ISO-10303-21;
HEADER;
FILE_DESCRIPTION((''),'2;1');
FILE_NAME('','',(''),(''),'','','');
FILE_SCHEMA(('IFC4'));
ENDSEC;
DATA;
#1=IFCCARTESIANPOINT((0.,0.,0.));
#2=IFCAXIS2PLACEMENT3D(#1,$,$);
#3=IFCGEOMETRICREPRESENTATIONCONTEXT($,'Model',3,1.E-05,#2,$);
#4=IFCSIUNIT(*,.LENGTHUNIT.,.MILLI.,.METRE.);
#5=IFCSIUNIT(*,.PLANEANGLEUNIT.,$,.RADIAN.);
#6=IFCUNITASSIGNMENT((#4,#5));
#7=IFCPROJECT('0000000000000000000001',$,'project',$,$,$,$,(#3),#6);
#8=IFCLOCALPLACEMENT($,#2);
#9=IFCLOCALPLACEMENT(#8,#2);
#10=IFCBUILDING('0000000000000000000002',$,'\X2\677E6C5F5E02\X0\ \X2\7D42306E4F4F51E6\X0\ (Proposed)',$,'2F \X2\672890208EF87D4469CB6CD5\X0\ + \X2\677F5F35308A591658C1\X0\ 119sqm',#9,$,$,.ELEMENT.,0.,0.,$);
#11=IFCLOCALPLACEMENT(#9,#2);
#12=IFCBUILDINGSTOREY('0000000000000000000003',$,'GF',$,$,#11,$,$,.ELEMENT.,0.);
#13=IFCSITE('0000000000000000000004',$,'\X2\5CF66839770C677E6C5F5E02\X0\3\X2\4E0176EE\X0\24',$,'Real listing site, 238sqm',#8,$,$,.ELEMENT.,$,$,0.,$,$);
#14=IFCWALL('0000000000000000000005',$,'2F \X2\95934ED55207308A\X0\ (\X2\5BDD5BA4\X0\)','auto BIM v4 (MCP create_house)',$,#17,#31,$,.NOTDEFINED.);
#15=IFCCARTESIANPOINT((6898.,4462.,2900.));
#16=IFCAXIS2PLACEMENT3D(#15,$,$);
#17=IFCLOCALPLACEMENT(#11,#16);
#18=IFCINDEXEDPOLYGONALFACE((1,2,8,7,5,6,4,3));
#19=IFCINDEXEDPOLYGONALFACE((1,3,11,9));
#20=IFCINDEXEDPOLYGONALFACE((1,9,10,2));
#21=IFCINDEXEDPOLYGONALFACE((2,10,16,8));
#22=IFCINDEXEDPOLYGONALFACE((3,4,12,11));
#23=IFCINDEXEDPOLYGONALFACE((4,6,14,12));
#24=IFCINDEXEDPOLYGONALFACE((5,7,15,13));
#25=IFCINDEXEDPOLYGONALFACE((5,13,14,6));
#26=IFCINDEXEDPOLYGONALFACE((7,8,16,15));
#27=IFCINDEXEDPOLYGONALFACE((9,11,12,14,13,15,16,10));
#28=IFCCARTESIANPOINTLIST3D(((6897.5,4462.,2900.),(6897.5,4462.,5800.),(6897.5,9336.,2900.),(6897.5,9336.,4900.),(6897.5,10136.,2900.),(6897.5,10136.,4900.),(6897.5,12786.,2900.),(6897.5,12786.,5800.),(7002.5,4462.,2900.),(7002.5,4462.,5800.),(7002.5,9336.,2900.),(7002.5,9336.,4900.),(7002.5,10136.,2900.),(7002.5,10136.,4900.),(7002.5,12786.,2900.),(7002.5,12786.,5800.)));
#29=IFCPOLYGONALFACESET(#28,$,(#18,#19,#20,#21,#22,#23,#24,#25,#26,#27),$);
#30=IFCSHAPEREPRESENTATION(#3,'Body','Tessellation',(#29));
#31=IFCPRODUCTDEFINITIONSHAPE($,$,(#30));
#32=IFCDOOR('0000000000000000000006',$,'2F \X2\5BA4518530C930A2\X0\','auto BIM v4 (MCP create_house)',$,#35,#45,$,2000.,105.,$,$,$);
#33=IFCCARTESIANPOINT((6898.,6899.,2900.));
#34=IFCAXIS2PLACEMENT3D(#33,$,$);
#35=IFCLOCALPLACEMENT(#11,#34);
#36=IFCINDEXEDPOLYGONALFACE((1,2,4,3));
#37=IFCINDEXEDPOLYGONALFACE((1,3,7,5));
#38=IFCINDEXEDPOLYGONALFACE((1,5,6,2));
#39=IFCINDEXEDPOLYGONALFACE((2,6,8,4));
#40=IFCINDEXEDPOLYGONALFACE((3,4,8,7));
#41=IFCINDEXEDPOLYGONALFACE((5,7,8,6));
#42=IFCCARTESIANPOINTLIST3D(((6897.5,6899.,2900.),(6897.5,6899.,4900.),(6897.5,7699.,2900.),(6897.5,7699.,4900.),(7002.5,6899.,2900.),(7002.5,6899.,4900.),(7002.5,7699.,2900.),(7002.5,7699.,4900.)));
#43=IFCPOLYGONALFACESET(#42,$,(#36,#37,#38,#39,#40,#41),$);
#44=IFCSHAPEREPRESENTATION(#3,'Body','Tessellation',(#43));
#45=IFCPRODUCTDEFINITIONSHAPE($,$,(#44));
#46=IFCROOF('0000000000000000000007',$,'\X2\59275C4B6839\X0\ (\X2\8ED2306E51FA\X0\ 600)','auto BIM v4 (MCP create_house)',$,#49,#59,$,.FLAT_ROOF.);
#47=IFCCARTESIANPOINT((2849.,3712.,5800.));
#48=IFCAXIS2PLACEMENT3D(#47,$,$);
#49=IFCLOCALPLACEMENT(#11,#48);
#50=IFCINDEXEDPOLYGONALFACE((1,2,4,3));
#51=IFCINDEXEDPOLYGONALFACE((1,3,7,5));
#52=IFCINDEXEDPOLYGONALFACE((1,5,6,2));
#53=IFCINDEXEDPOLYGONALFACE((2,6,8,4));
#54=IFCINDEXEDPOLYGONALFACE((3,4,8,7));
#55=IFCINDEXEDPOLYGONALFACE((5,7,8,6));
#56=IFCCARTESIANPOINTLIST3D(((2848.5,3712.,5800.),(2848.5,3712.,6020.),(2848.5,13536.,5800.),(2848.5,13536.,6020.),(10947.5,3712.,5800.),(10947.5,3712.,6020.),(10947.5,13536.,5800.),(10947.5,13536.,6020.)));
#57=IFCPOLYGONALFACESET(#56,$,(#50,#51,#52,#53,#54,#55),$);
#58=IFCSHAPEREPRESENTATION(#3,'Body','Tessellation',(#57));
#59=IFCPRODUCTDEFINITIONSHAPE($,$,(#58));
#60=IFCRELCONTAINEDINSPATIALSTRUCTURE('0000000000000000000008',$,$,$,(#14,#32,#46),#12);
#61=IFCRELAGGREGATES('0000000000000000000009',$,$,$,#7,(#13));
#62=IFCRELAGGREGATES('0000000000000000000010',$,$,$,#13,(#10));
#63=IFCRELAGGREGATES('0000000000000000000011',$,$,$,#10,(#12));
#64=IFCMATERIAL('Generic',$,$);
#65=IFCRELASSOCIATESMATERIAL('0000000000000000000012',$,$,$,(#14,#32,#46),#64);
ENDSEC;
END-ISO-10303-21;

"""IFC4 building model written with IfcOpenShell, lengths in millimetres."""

from ifc_helpers import new_model, si_unit, frame, frame_2d, origin, place, context, project, spatial, rectangle, extrude, material, element, fill, save


model = new_model("IFC4")

# Units and contexts
model_context = context("Model", 3, precision=1e-05, world=origin())
ifc_project = project(units=[si_unit("LENGTHUNIT", "METRE", prefix="MILLI"), si_unit("PLANEANGLEUNIT", "RADIAN")], contexts=[model_context])

# Site, building, storey
site_placement = place(None, origin())
site = spatial("IfcSite", under=ifc_project, at=site_placement, Name="島根県松江市3丁目24", ObjectType="Real listing site, 238sqm", CompositionType="ELEMENT", RefElevation=0.0)
building_placement = place(site_placement, origin())
building = spatial("IfcBuilding", under=site, at=building_placement, Name="松江市 終の住処 (Proposed)", ObjectType="2F 木造軸組構法 + 板張り外壁 119sqm", CompositionType="ELEMENT", ElevationOfRefHeight=0.0, ElevationOfTerrain=0.0)
storey_placement = place(building_placement, origin())
storey = spatial("IfcBuildingStorey", under=building, at=storey_placement, Name="GF", CompositionType="ELEMENT", Elevation=0.0)

# Shared definitions
ifc_material = material(Name="Generic")

# Wall, opening, door
wall_1_placement = place(storey_placement, frame((6898.0, 4462.0, 2900.0)))
wall_1 = element("IfcWall", 1, at=wall_1_placement, inside=storey, material=ifc_material, Name="2F 間仕切り (寝室)", Description="auto BIM v4 (MCP create_house)", PredefinedType="NOTDEFINED", context=model_context, shape_type="SweptSolid", body=[
    extrude(rectangle(XDim=105.0, YDim=8324.0, at=frame_2d((52.0, 4162.0))), frame((6898.0, 4462.0, 2900.0)), (0.0, 0.0, 1.0), 2900.0),
])
opening_1_placement = place(storey_placement, frame((6898.0, 6899.0, 2900.0)))
opening_1 = element("IfcOpeningElement", 2, at=opening_1_placement, cuts=wall_1, PredefinedType="NOTDEFINED", context=model_context, shape_type="SweptSolid", body=[
    extrude(rectangle(XDim=105.0, YDim=800.0, at=frame_2d((52.0, 400.0))), frame((6898.0, 6899.0, 2900.0)), (0.0, 0.0, 1.0), 2000.0),
])
door_1_placement = place(storey_placement, frame((6898.0, 6899.0, 2900.0)))
door_1 = element("IfcDoor", 3, at=door_1_placement, inside=storey, material=ifc_material, Name="2F 室内ドア", Description="auto BIM v4 (MCP create_house)", OverallHeight=2000.0, OverallWidth=105.0, context=model_context, shape_type="SweptSolid", body=[
    extrude(rectangle(XDim=105.0, YDim=800.0, at=frame_2d((52.0, 400.0))), frame((6898.0, 6899.0, 2900.0)), (0.0, 0.0, 1.0), 2000.0),
])
fill(opening_1, door_1)

# Roof
roof_placement = place(storey_placement, frame((2849.0, 3712.0, 5800.0)))
element("IfcRoof", 4, at=roof_placement, inside=storey, material=ifc_material, Name="大屋根 (軒の出 600)", Description="auto BIM v4 (MCP create_house)", PredefinedType="FLAT_ROOF", context=model_context, shape_type="SweptSolid", body=[
    extrude(rectangle(XDim=8099.0, YDim=9824.0, at=frame_2d((4049.0, 4912.0))), frame((2849.0, 3712.0, 5800.0)), (0.0, 0.0, 1.0), 220.0),
])

save(model, "model.ifc")
